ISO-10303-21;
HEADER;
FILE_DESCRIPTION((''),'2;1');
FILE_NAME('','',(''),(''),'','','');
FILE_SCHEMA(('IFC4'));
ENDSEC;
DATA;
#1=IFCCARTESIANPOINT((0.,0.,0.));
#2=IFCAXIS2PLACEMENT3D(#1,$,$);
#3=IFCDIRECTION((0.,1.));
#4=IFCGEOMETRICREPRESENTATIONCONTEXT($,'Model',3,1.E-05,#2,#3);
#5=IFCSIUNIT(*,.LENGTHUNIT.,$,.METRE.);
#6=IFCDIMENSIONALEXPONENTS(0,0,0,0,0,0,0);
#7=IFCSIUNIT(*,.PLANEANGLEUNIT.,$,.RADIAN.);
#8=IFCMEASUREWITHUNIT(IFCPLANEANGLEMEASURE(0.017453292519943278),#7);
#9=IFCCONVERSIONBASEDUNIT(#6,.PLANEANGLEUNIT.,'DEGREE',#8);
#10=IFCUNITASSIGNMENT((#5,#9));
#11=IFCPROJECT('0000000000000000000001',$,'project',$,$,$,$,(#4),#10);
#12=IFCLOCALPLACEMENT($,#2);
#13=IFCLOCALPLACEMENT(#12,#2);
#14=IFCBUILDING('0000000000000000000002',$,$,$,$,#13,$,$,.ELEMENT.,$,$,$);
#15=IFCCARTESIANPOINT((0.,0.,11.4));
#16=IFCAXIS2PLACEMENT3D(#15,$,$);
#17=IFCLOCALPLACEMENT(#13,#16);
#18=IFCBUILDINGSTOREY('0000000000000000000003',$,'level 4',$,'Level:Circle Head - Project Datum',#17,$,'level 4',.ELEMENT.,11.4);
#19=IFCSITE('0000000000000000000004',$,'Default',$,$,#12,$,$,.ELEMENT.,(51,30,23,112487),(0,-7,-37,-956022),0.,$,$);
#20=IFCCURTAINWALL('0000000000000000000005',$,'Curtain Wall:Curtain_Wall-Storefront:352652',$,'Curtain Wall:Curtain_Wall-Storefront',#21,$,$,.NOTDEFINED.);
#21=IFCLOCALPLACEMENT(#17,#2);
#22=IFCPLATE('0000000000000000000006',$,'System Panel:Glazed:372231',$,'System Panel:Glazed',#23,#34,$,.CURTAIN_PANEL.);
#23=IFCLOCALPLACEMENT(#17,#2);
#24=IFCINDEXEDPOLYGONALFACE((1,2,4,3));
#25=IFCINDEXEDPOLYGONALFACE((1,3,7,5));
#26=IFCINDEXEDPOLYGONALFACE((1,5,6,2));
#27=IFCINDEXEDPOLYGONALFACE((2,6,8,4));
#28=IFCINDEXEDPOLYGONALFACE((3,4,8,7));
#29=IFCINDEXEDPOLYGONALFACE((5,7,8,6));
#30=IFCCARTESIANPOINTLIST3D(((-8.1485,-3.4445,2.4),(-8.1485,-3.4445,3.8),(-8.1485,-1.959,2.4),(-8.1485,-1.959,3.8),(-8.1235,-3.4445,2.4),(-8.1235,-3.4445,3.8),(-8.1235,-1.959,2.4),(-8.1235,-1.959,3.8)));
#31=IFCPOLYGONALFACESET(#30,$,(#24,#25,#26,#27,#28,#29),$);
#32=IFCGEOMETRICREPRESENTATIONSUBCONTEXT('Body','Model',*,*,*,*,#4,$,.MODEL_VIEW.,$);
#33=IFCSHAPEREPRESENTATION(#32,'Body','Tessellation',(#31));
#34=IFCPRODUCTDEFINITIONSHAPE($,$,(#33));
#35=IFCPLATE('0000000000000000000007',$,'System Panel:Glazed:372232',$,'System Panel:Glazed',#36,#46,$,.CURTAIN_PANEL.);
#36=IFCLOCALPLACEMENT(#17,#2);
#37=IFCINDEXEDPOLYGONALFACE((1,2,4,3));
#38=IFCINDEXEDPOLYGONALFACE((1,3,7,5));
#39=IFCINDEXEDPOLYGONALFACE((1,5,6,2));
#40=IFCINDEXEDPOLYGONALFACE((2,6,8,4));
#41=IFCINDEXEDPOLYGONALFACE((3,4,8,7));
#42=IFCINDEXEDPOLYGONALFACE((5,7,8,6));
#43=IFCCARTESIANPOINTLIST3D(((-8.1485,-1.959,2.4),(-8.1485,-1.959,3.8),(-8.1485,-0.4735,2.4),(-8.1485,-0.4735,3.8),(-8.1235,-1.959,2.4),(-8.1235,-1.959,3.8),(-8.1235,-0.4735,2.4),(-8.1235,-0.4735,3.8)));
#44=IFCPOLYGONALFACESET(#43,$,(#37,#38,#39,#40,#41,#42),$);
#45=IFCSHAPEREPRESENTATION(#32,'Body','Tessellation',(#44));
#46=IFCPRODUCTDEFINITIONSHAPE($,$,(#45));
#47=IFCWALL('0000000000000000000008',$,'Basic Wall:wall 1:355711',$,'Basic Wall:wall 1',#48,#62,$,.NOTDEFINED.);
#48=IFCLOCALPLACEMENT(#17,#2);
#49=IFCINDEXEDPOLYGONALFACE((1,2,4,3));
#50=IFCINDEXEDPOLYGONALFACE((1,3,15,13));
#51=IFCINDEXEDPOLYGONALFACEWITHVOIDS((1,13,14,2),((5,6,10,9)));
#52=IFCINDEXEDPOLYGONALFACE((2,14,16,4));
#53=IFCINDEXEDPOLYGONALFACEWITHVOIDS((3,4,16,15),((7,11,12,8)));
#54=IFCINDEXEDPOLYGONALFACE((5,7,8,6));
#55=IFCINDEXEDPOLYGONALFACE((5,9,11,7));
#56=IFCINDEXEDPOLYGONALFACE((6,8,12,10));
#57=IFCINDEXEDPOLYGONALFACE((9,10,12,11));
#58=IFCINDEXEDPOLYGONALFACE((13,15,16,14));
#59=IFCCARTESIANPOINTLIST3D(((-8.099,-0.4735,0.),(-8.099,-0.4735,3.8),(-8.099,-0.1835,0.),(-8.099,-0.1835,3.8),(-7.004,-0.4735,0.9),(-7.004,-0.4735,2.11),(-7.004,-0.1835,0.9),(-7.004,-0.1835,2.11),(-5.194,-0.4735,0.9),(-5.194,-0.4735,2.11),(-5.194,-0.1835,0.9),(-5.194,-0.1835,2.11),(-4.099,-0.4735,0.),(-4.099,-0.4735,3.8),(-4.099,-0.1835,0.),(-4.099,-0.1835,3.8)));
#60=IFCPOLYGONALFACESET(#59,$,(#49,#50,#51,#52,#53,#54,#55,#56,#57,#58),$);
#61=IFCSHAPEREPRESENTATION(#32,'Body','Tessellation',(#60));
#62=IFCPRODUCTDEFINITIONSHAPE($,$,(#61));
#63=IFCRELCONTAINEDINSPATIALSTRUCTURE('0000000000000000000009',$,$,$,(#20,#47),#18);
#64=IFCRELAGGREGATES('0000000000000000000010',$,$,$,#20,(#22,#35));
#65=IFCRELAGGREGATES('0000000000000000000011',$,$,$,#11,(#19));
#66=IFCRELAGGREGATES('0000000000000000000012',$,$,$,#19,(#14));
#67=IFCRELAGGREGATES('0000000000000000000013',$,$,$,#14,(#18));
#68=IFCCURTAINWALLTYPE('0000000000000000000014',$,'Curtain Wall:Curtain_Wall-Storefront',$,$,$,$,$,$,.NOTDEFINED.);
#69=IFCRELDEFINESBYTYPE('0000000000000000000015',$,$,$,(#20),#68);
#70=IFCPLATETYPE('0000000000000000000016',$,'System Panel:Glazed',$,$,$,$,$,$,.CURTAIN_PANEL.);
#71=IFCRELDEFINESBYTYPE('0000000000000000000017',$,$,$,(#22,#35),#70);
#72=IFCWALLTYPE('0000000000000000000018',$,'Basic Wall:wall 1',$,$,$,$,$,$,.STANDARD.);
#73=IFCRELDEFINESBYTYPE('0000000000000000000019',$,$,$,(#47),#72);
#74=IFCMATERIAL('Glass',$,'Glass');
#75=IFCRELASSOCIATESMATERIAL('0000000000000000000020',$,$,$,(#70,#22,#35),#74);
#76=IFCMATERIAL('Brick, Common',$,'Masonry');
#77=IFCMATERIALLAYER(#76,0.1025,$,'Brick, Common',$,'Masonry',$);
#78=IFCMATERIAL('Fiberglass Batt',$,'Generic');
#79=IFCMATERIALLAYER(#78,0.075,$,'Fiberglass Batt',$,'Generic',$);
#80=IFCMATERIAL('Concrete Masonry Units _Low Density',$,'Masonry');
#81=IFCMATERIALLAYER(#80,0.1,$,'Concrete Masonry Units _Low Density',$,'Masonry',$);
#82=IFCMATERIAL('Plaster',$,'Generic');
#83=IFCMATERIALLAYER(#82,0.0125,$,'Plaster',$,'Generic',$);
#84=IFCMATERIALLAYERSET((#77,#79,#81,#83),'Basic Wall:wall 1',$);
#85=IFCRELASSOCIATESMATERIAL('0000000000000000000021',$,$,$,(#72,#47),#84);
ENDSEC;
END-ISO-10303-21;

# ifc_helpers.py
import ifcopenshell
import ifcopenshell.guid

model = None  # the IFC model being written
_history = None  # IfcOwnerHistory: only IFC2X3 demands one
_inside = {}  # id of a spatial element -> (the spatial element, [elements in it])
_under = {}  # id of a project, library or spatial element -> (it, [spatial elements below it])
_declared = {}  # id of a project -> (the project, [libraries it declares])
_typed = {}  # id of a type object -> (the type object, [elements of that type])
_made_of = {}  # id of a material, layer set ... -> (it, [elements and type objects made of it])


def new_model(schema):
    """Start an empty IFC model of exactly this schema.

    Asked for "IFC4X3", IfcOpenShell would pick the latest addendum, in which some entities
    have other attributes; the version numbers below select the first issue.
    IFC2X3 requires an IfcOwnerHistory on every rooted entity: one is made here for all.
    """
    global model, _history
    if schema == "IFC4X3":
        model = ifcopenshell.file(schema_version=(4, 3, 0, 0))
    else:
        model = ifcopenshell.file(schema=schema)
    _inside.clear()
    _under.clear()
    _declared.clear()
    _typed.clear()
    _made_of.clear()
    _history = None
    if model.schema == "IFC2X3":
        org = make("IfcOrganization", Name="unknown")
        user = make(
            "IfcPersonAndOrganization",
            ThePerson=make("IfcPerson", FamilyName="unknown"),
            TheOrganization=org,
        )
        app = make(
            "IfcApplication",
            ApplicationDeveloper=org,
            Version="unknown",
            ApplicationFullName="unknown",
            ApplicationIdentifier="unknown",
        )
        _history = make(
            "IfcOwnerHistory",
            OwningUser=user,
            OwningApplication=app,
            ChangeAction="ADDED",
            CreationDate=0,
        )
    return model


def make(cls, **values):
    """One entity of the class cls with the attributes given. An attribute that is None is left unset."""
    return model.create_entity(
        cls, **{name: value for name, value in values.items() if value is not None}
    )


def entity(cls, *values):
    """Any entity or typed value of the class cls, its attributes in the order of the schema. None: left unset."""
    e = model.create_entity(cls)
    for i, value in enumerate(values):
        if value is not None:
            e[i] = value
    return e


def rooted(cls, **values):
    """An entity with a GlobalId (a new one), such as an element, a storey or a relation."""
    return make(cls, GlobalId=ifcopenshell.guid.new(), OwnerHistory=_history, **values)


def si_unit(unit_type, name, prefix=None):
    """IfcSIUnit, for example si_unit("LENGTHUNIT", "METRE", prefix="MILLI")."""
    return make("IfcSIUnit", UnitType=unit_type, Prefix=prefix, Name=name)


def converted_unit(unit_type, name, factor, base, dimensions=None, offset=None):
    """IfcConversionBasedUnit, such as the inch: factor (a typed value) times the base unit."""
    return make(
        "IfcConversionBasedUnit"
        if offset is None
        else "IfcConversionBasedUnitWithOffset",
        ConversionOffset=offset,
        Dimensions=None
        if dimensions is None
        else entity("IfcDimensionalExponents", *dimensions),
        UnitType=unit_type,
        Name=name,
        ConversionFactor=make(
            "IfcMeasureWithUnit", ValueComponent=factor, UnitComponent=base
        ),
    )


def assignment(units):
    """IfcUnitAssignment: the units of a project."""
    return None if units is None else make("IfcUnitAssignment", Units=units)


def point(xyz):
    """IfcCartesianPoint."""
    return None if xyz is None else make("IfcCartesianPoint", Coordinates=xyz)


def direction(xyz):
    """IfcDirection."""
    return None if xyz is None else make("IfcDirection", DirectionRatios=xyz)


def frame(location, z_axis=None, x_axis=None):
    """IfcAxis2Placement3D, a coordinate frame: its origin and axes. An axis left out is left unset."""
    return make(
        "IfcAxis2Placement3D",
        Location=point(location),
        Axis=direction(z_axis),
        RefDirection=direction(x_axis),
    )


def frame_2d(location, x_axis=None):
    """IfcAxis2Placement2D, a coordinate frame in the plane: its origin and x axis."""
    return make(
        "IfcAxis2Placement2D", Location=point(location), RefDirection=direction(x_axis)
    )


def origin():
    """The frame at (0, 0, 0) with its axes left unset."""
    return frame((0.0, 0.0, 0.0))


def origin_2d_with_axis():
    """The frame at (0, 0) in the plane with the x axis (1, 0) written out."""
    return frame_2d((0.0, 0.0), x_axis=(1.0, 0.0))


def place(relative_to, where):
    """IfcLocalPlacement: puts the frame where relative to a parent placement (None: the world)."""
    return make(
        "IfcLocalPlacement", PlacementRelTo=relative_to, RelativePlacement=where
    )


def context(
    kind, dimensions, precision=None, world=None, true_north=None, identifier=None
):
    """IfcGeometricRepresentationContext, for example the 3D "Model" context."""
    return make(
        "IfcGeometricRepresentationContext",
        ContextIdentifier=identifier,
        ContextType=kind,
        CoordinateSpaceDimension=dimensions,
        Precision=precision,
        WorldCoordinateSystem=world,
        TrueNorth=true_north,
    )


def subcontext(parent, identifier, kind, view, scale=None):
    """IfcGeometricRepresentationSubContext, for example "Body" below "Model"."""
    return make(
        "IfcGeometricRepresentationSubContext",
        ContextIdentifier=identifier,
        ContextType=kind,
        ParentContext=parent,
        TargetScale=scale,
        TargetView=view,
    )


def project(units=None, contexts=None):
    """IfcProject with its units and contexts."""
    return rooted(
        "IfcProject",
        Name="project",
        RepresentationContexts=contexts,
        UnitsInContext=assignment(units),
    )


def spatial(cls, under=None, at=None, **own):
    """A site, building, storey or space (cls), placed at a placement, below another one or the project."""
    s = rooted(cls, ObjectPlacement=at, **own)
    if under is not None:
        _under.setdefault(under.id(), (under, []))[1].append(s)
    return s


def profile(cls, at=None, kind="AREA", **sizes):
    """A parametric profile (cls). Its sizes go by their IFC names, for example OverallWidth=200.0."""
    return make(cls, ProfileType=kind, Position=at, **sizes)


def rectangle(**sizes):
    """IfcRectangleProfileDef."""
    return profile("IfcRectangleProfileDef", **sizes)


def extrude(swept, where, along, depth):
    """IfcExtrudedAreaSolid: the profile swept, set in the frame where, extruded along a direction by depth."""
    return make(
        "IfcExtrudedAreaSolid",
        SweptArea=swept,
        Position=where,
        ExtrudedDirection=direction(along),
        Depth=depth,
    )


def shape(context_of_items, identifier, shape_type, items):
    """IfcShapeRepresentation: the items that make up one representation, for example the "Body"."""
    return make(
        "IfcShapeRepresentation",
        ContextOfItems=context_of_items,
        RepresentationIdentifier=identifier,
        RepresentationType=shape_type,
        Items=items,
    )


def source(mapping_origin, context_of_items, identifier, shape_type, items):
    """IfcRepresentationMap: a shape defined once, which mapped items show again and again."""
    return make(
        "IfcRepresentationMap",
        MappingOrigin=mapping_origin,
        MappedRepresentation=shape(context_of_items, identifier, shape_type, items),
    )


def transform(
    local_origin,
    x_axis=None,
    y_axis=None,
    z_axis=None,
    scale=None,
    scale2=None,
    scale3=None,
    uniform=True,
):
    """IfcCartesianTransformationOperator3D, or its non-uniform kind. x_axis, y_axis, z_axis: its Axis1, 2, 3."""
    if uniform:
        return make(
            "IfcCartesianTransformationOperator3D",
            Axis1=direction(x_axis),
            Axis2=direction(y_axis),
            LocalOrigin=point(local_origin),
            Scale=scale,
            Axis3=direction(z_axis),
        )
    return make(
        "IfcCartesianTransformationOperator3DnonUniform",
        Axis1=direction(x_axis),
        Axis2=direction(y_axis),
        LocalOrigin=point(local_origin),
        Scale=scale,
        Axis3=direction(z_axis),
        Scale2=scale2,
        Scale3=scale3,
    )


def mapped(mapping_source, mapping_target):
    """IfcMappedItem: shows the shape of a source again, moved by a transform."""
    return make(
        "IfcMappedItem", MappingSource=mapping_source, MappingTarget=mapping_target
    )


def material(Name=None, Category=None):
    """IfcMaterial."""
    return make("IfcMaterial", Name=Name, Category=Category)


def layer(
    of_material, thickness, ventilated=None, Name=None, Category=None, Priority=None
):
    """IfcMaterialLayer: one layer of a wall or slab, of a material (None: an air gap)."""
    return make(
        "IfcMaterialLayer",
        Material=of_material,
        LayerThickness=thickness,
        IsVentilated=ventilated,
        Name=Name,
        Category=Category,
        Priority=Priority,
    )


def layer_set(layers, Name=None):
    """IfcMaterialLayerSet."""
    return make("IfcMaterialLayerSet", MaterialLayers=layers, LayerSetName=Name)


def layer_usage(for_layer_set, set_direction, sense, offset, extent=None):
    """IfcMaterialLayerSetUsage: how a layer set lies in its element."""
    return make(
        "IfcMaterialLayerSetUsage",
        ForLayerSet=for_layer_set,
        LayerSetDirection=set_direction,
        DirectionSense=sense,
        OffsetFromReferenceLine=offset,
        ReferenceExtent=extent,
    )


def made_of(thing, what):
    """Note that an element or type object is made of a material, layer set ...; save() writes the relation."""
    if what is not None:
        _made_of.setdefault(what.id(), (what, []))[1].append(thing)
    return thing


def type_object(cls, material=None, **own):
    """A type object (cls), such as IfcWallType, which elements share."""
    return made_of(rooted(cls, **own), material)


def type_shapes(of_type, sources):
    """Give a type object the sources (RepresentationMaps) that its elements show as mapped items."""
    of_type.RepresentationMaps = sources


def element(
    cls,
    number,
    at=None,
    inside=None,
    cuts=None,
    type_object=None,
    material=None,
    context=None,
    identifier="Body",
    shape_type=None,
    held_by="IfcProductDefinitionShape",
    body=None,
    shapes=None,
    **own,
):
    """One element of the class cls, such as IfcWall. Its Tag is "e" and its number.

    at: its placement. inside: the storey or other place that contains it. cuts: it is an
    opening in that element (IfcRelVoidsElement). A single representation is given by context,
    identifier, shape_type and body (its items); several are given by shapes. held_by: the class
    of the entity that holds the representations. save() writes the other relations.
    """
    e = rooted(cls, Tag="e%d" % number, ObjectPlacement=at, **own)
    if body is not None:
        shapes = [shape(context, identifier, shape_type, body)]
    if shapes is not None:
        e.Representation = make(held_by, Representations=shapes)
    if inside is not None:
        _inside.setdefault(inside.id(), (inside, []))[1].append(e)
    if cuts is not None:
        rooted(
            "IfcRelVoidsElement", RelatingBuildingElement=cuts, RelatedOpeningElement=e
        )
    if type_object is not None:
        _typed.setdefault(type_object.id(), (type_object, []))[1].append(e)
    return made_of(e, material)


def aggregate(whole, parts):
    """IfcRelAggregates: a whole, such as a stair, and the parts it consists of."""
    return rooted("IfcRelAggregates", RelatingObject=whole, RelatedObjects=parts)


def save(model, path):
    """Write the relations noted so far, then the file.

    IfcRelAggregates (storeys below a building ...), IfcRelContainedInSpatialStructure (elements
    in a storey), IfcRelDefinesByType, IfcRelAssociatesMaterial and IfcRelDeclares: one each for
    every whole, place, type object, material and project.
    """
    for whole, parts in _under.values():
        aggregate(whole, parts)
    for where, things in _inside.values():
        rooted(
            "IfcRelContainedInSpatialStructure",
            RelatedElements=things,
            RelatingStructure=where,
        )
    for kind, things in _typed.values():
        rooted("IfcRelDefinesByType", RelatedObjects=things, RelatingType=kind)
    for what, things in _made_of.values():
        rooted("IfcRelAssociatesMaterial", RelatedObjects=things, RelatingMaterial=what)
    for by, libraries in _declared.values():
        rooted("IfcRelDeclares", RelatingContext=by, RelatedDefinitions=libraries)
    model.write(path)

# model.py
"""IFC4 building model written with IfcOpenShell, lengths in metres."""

from ifc_helpers import new_model, entity, si_unit, converted_unit, direction, frame, frame_2d, origin, origin_2d_with_axis, place, context, subcontext, project, spatial, rectangle, extrude, source, transform, mapped, material, layer, layer_set, layer_usage, type_object, type_shapes, element, aggregate, save


model = new_model("IFC4")

# Units and contexts
model_context = context("Model", 3, precision=1e-05, world=origin(), true_north=direction((0.0, 1.0)))
body_context = subcontext(model_context, "Body", "Model", "MODEL_VIEW")
ifc_project = project(units=[si_unit("LENGTHUNIT", "METRE"), converted_unit("PLANEANGLEUNIT", "DEGREE", entity("IfcPlaneAngleMeasure", 0.017453292519943278), si_unit("PLANEANGLEUNIT", "RADIAN"), dimensions=[0, 0, 0, 0, 0, 0, 0])], contexts=[model_context])

# Site, building, storey
site_placement = place(None, origin())
site = spatial("IfcSite", under=ifc_project, at=site_placement, Name="Default", CompositionType="ELEMENT", RefLatitude=(51, 30, 23, 112487), RefLongitude=(0, -7, -37, -956022), RefElevation=0.0)
building_placement = place(site_placement, origin())
building = spatial("IfcBuilding", under=site, at=building_placement, CompositionType="ELEMENT")
storey_placement = place(building_placement, frame((0.0, 0.0, 11.4)))
storey = spatial("IfcBuildingStorey", under=building, at=storey_placement, Name="level 4", ObjectType="Level:Circle Head - Project Datum", LongName="level 4", CompositionType="ELEMENT", Elevation=11.4)

# Curtain wall
curtain_wall_type = type_object("IfcCurtainWallType", Name="Curtain Wall:Curtain_Wall-Storefront", PredefinedType="NOTDEFINED")
ifc_material_1 = material(Name="Glass", Category="Glass")
curtain_wall_1_placement = place(storey_placement, frame((0.0, 0.0, -11.4)))
curtain_wall_1 = element("IfcCurtainWall", 1, at=curtain_wall_1_placement, inside=storey, type_object=curtain_wall_type, Name="Curtain Wall:Curtain_Wall-Storefront:352652", ObjectType="Curtain Wall:Curtain_Wall-Storefront", PredefinedType="NOTDEFINED")

# Plates
plate_type_1 = type_object("IfcPlateType", Name="System Panel:Glazed", PredefinedType="CURTAIN_PANEL", material=ifc_material_1)
shared_shape_1 = source(origin(), body_context, "Body", "SweptSolid", [
    extrude(rectangle(XDim=0.025, YDim=1.4855, at=origin_2d_with_axis()), frame((0.7428, 0.0125, 0.0), z_axis=(0.0, 0.0, 1.0), x_axis=(0.0, 1.0, 0.0)), (0.0, 0.0, 1.0), 1.4),
])
type_shapes(plate_type_1, [shared_shape_1])
plate_1_placement = place(curtain_wall_1_placement, frame((-8.1235, -3.4445, 13.8), z_axis=(0.0, 0.0, 1.0), x_axis=(0.0, 1.0, 0.0)))
plate_1 = element("IfcPlate", 2, at=plate_1_placement, type_object=plate_type_1, material=ifc_material_1, Name="System Panel:Glazed:372231", ObjectType="System Panel:Glazed", PredefinedType="CURTAIN_PANEL", context=body_context, shape_type="MappedRepresentation", body=[
    mapped(shared_shape_1, transform((0.0, 0.0, 0.0), scale=1.0)),
])
plate_2_placement = place(curtain_wall_1_placement, frame((-8.1235, -1.959, 13.8), z_axis=(0.0, 0.0, 1.0), x_axis=(0.0, 1.0, 0.0)))
plate_2 = element("IfcPlate", 3, at=plate_2_placement, type_object=plate_type_1, material=ifc_material_1, Name="System Panel:Glazed:372232", ObjectType="System Panel:Glazed", PredefinedType="CURTAIN_PANEL", context=body_context, shape_type="MappedRepresentation", body=[
    mapped(shared_shape_1, transform((0.0, 0.0, 0.0), scale=1.0)),
])
aggregate(curtain_wall_1, [plate_1, plate_2])

# Wall, opening
ifc_material_2 = material(Name="Brick, Common", Category="Masonry")
ifc_layer_1 = layer(ifc_material_2, 0.1025, Name="Brick, Common", Category="Masonry")
ifc_material_3 = material(Name="Fiberglass Batt", Category="Generic")
ifc_layer_2 = layer(ifc_material_3, 0.075, Name="Fiberglass Batt", Category="Generic")
ifc_material_4 = material(Name="Concrete Masonry Units _Low Density", Category="Masonry")
ifc_layer_3 = layer(ifc_material_4, 0.1, Name="Concrete Masonry Units _Low Density", Category="Masonry")
ifc_material_5 = material(Name="Plaster", Category="Generic")
ifc_layer_4 = layer(ifc_material_5, 0.0125, Name="Plaster", Category="Generic")
ifc_layer_set_1 = layer_set([ifc_layer_1, ifc_layer_2, ifc_layer_3, ifc_layer_4], Name="Basic Wall:wall 1")
ifc_layer_usage_1 = layer_usage(ifc_layer_set_1, "AXIS2", "NEGATIVE", 0.145)
wall_type = type_object("IfcWallType", Name="Basic Wall:wall 1", PredefinedType="STANDARD", material=ifc_layer_set_1)
wall_placement = place(storey_placement, frame((-8.099, -0.3285, 0.0)))
wall = element("IfcWall", 4, at=wall_placement, inside=storey, type_object=wall_type, material=ifc_layer_usage_1, Name="Basic Wall:wall 1:355711", ObjectType="Basic Wall:wall 1", PredefinedType="NOTDEFINED", context=body_context, shape_type="SweptSolid", body=[
    extrude(rectangle(XDim=4.0, YDim=0.29, at=frame_2d((2.0, 0.0), x_axis=(-1.0, 0.0))), origin(), (0.0, 0.0, 1.0), 3.8),
])
opening_1_placement = place(wall_placement, frame((1.095, -0.145, 0.9)))
element("IfcOpeningElement", 5, at=opening_1_placement, cuts=wall, PredefinedType="OPENING", context=body_context, shape_type="SweptSolid", body=[
    extrude(rectangle(XDim=1.21, YDim=1.81, at=frame_2d((0.605, 0.905), x_axis=(-1.0, 0.0))), frame((0.0, 0.0, 0.0), z_axis=(0.0, 1.0, 0.0), x_axis=(0.0, 0.0, 1.0)), (0.0, 0.0, 1.0), 0.29),
])

save(model, "model.ifc")
